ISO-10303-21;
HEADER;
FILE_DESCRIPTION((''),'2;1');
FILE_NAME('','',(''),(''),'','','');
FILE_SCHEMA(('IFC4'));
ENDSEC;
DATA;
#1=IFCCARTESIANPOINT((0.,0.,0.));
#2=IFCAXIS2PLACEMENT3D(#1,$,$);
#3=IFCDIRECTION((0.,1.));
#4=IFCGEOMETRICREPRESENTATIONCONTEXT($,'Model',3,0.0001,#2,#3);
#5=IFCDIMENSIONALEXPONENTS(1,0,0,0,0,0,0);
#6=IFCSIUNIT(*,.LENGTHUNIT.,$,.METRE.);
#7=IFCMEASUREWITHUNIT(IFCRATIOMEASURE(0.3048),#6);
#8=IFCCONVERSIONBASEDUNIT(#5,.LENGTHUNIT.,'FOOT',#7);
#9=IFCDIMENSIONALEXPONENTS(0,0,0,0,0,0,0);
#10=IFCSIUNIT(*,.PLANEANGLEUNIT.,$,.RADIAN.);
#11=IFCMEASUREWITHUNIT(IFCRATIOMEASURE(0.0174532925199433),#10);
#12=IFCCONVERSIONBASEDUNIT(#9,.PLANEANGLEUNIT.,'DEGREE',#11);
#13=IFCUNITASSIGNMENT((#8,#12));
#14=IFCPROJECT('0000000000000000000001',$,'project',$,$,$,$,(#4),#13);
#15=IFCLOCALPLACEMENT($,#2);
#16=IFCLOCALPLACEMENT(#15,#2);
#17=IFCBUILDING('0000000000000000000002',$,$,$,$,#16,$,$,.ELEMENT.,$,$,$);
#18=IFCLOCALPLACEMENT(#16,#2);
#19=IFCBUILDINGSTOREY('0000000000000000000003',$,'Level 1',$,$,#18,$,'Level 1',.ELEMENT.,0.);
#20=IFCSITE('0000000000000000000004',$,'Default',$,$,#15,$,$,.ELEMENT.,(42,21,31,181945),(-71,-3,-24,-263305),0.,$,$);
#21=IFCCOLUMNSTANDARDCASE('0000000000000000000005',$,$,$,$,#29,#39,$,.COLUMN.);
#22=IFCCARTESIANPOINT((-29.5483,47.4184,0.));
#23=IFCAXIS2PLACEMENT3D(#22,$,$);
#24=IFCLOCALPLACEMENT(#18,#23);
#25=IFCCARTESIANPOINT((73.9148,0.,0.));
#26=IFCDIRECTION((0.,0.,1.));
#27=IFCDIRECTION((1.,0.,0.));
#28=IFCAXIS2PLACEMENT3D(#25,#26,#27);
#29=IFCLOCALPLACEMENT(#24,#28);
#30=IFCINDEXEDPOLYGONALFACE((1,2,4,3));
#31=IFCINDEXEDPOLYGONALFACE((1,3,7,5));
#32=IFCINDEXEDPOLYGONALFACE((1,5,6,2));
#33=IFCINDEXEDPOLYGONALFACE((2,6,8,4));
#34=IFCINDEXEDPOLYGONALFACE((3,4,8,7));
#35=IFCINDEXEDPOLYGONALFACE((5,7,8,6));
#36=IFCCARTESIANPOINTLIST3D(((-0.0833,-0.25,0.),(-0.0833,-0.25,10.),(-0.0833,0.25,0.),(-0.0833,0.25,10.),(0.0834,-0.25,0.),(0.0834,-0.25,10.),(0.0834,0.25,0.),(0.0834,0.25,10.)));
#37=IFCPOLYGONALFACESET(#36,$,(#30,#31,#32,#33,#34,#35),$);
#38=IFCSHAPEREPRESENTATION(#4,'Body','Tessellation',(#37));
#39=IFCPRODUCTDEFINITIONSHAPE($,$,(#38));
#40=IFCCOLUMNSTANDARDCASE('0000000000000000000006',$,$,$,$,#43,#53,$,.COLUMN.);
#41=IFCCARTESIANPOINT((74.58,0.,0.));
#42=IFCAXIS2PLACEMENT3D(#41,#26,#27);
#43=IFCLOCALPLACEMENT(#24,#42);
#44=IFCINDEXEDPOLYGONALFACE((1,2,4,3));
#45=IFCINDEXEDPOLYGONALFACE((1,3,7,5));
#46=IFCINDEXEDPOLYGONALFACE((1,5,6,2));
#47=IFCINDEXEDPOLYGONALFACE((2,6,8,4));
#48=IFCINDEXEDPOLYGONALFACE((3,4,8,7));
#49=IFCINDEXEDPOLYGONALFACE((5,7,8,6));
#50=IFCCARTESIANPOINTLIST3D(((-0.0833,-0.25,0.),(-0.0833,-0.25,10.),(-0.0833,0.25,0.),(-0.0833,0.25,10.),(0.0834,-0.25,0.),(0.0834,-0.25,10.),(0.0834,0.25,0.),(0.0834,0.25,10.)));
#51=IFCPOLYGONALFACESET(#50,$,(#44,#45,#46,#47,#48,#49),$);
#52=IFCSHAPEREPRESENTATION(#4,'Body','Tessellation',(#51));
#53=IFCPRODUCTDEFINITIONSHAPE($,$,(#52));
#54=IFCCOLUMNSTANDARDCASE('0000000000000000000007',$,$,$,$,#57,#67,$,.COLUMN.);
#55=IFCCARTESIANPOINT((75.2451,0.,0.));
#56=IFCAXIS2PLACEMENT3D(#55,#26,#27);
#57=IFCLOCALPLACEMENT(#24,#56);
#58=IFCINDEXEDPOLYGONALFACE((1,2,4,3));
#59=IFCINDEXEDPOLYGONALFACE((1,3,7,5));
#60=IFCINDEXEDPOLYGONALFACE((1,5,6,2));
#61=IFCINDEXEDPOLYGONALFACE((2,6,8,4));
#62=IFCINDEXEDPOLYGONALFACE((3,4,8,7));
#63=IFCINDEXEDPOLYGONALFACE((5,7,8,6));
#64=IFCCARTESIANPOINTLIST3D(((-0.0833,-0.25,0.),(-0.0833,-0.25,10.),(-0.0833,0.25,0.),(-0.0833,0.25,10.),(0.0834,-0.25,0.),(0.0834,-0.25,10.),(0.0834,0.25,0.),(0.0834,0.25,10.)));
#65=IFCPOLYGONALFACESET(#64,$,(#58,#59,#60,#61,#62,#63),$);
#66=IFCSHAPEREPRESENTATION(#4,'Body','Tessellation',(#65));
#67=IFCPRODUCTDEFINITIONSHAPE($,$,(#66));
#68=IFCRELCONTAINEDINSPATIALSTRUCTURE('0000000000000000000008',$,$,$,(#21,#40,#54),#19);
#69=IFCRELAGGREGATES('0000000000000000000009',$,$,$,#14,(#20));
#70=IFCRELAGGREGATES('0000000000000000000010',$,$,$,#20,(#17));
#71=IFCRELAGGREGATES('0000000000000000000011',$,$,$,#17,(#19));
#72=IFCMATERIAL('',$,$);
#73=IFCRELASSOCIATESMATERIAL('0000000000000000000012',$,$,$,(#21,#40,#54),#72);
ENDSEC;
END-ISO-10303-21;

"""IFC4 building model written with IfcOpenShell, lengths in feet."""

from ifc_helpers import new_model, entity, si_unit, converted_unit, direction, frame, origin, place, context, project, spatial, rectangle, extrude, material, element, save


model = new_model("IFC4")

# Units and contexts
model_context = context("Model", 3, precision=0.0001, world=origin(), true_north=direction((0.0, 1.0)))
ifc_project = project(units=[converted_unit("LENGTHUNIT", "FOOT", entity("IfcRatioMeasure", 0.3048), si_unit("LENGTHUNIT", "METRE"), dimensions=[1, 0, 0, 0, 0, 0, 0]), converted_unit("PLANEANGLEUNIT", "DEGREE", entity("IfcRatioMeasure", 0.0174532925199433), si_unit("PLANEANGLEUNIT", "RADIAN"), dimensions=[0, 0, 0, 0, 0, 0, 0])], contexts=[model_context])

# Site, building, storey
site_placement = place(None, origin())
site = spatial("IfcSite", under=ifc_project, at=site_placement, Name="Default", CompositionType="ELEMENT", RefLatitude=(42, 21, 31, 181945), RefLongitude=(-71, -3, -24, -263305), RefElevation=0.0)
building_placement = place(site_placement, origin())
building = spatial("IfcBuilding", under=site, at=building_placement, CompositionType="ELEMENT")
storey_placement = place(building_placement, origin())
storey = spatial("IfcBuildingStorey", under=building, at=storey_placement, Name="Level 1", LongName="Level 1", CompositionType="ELEMENT", Elevation=0.0)

# Columns
ifc_material_1 = material(Name="")
placement = place(storey_placement, frame((-29.5483, 47.4184, 0.0)))
for number, where, z_axis, x_axis in (
    (1, (73.9148, 0.0, 0.0), (0.0, 0.0, 1.0), (1.0, 0.0, 0.0)),
    (2, (74.58, 0.0, 0.0), (0.0, 0.0, 1.0), (1.0, 0.0, 0.0)),
    (3, (75.2451, 0.0, 0.0), (0.0, 0.0, 1.0), (1.0, 0.0, 0.0)),
):
    element("IfcColumnStandardCase", number, at=place(placement, frame(where, z_axis=z_axis, x_axis=x_axis)), inside=storey, material=ifc_material_1, PredefinedType="COLUMN", context=model_context, shape_type="SweptSolid", body=[
        extrude(rectangle(XDim=0.1667, YDim=0.5), origin(), (0.0, 0.0, 1.0), 10.0),
    ])

save(model, "model.ifc")
